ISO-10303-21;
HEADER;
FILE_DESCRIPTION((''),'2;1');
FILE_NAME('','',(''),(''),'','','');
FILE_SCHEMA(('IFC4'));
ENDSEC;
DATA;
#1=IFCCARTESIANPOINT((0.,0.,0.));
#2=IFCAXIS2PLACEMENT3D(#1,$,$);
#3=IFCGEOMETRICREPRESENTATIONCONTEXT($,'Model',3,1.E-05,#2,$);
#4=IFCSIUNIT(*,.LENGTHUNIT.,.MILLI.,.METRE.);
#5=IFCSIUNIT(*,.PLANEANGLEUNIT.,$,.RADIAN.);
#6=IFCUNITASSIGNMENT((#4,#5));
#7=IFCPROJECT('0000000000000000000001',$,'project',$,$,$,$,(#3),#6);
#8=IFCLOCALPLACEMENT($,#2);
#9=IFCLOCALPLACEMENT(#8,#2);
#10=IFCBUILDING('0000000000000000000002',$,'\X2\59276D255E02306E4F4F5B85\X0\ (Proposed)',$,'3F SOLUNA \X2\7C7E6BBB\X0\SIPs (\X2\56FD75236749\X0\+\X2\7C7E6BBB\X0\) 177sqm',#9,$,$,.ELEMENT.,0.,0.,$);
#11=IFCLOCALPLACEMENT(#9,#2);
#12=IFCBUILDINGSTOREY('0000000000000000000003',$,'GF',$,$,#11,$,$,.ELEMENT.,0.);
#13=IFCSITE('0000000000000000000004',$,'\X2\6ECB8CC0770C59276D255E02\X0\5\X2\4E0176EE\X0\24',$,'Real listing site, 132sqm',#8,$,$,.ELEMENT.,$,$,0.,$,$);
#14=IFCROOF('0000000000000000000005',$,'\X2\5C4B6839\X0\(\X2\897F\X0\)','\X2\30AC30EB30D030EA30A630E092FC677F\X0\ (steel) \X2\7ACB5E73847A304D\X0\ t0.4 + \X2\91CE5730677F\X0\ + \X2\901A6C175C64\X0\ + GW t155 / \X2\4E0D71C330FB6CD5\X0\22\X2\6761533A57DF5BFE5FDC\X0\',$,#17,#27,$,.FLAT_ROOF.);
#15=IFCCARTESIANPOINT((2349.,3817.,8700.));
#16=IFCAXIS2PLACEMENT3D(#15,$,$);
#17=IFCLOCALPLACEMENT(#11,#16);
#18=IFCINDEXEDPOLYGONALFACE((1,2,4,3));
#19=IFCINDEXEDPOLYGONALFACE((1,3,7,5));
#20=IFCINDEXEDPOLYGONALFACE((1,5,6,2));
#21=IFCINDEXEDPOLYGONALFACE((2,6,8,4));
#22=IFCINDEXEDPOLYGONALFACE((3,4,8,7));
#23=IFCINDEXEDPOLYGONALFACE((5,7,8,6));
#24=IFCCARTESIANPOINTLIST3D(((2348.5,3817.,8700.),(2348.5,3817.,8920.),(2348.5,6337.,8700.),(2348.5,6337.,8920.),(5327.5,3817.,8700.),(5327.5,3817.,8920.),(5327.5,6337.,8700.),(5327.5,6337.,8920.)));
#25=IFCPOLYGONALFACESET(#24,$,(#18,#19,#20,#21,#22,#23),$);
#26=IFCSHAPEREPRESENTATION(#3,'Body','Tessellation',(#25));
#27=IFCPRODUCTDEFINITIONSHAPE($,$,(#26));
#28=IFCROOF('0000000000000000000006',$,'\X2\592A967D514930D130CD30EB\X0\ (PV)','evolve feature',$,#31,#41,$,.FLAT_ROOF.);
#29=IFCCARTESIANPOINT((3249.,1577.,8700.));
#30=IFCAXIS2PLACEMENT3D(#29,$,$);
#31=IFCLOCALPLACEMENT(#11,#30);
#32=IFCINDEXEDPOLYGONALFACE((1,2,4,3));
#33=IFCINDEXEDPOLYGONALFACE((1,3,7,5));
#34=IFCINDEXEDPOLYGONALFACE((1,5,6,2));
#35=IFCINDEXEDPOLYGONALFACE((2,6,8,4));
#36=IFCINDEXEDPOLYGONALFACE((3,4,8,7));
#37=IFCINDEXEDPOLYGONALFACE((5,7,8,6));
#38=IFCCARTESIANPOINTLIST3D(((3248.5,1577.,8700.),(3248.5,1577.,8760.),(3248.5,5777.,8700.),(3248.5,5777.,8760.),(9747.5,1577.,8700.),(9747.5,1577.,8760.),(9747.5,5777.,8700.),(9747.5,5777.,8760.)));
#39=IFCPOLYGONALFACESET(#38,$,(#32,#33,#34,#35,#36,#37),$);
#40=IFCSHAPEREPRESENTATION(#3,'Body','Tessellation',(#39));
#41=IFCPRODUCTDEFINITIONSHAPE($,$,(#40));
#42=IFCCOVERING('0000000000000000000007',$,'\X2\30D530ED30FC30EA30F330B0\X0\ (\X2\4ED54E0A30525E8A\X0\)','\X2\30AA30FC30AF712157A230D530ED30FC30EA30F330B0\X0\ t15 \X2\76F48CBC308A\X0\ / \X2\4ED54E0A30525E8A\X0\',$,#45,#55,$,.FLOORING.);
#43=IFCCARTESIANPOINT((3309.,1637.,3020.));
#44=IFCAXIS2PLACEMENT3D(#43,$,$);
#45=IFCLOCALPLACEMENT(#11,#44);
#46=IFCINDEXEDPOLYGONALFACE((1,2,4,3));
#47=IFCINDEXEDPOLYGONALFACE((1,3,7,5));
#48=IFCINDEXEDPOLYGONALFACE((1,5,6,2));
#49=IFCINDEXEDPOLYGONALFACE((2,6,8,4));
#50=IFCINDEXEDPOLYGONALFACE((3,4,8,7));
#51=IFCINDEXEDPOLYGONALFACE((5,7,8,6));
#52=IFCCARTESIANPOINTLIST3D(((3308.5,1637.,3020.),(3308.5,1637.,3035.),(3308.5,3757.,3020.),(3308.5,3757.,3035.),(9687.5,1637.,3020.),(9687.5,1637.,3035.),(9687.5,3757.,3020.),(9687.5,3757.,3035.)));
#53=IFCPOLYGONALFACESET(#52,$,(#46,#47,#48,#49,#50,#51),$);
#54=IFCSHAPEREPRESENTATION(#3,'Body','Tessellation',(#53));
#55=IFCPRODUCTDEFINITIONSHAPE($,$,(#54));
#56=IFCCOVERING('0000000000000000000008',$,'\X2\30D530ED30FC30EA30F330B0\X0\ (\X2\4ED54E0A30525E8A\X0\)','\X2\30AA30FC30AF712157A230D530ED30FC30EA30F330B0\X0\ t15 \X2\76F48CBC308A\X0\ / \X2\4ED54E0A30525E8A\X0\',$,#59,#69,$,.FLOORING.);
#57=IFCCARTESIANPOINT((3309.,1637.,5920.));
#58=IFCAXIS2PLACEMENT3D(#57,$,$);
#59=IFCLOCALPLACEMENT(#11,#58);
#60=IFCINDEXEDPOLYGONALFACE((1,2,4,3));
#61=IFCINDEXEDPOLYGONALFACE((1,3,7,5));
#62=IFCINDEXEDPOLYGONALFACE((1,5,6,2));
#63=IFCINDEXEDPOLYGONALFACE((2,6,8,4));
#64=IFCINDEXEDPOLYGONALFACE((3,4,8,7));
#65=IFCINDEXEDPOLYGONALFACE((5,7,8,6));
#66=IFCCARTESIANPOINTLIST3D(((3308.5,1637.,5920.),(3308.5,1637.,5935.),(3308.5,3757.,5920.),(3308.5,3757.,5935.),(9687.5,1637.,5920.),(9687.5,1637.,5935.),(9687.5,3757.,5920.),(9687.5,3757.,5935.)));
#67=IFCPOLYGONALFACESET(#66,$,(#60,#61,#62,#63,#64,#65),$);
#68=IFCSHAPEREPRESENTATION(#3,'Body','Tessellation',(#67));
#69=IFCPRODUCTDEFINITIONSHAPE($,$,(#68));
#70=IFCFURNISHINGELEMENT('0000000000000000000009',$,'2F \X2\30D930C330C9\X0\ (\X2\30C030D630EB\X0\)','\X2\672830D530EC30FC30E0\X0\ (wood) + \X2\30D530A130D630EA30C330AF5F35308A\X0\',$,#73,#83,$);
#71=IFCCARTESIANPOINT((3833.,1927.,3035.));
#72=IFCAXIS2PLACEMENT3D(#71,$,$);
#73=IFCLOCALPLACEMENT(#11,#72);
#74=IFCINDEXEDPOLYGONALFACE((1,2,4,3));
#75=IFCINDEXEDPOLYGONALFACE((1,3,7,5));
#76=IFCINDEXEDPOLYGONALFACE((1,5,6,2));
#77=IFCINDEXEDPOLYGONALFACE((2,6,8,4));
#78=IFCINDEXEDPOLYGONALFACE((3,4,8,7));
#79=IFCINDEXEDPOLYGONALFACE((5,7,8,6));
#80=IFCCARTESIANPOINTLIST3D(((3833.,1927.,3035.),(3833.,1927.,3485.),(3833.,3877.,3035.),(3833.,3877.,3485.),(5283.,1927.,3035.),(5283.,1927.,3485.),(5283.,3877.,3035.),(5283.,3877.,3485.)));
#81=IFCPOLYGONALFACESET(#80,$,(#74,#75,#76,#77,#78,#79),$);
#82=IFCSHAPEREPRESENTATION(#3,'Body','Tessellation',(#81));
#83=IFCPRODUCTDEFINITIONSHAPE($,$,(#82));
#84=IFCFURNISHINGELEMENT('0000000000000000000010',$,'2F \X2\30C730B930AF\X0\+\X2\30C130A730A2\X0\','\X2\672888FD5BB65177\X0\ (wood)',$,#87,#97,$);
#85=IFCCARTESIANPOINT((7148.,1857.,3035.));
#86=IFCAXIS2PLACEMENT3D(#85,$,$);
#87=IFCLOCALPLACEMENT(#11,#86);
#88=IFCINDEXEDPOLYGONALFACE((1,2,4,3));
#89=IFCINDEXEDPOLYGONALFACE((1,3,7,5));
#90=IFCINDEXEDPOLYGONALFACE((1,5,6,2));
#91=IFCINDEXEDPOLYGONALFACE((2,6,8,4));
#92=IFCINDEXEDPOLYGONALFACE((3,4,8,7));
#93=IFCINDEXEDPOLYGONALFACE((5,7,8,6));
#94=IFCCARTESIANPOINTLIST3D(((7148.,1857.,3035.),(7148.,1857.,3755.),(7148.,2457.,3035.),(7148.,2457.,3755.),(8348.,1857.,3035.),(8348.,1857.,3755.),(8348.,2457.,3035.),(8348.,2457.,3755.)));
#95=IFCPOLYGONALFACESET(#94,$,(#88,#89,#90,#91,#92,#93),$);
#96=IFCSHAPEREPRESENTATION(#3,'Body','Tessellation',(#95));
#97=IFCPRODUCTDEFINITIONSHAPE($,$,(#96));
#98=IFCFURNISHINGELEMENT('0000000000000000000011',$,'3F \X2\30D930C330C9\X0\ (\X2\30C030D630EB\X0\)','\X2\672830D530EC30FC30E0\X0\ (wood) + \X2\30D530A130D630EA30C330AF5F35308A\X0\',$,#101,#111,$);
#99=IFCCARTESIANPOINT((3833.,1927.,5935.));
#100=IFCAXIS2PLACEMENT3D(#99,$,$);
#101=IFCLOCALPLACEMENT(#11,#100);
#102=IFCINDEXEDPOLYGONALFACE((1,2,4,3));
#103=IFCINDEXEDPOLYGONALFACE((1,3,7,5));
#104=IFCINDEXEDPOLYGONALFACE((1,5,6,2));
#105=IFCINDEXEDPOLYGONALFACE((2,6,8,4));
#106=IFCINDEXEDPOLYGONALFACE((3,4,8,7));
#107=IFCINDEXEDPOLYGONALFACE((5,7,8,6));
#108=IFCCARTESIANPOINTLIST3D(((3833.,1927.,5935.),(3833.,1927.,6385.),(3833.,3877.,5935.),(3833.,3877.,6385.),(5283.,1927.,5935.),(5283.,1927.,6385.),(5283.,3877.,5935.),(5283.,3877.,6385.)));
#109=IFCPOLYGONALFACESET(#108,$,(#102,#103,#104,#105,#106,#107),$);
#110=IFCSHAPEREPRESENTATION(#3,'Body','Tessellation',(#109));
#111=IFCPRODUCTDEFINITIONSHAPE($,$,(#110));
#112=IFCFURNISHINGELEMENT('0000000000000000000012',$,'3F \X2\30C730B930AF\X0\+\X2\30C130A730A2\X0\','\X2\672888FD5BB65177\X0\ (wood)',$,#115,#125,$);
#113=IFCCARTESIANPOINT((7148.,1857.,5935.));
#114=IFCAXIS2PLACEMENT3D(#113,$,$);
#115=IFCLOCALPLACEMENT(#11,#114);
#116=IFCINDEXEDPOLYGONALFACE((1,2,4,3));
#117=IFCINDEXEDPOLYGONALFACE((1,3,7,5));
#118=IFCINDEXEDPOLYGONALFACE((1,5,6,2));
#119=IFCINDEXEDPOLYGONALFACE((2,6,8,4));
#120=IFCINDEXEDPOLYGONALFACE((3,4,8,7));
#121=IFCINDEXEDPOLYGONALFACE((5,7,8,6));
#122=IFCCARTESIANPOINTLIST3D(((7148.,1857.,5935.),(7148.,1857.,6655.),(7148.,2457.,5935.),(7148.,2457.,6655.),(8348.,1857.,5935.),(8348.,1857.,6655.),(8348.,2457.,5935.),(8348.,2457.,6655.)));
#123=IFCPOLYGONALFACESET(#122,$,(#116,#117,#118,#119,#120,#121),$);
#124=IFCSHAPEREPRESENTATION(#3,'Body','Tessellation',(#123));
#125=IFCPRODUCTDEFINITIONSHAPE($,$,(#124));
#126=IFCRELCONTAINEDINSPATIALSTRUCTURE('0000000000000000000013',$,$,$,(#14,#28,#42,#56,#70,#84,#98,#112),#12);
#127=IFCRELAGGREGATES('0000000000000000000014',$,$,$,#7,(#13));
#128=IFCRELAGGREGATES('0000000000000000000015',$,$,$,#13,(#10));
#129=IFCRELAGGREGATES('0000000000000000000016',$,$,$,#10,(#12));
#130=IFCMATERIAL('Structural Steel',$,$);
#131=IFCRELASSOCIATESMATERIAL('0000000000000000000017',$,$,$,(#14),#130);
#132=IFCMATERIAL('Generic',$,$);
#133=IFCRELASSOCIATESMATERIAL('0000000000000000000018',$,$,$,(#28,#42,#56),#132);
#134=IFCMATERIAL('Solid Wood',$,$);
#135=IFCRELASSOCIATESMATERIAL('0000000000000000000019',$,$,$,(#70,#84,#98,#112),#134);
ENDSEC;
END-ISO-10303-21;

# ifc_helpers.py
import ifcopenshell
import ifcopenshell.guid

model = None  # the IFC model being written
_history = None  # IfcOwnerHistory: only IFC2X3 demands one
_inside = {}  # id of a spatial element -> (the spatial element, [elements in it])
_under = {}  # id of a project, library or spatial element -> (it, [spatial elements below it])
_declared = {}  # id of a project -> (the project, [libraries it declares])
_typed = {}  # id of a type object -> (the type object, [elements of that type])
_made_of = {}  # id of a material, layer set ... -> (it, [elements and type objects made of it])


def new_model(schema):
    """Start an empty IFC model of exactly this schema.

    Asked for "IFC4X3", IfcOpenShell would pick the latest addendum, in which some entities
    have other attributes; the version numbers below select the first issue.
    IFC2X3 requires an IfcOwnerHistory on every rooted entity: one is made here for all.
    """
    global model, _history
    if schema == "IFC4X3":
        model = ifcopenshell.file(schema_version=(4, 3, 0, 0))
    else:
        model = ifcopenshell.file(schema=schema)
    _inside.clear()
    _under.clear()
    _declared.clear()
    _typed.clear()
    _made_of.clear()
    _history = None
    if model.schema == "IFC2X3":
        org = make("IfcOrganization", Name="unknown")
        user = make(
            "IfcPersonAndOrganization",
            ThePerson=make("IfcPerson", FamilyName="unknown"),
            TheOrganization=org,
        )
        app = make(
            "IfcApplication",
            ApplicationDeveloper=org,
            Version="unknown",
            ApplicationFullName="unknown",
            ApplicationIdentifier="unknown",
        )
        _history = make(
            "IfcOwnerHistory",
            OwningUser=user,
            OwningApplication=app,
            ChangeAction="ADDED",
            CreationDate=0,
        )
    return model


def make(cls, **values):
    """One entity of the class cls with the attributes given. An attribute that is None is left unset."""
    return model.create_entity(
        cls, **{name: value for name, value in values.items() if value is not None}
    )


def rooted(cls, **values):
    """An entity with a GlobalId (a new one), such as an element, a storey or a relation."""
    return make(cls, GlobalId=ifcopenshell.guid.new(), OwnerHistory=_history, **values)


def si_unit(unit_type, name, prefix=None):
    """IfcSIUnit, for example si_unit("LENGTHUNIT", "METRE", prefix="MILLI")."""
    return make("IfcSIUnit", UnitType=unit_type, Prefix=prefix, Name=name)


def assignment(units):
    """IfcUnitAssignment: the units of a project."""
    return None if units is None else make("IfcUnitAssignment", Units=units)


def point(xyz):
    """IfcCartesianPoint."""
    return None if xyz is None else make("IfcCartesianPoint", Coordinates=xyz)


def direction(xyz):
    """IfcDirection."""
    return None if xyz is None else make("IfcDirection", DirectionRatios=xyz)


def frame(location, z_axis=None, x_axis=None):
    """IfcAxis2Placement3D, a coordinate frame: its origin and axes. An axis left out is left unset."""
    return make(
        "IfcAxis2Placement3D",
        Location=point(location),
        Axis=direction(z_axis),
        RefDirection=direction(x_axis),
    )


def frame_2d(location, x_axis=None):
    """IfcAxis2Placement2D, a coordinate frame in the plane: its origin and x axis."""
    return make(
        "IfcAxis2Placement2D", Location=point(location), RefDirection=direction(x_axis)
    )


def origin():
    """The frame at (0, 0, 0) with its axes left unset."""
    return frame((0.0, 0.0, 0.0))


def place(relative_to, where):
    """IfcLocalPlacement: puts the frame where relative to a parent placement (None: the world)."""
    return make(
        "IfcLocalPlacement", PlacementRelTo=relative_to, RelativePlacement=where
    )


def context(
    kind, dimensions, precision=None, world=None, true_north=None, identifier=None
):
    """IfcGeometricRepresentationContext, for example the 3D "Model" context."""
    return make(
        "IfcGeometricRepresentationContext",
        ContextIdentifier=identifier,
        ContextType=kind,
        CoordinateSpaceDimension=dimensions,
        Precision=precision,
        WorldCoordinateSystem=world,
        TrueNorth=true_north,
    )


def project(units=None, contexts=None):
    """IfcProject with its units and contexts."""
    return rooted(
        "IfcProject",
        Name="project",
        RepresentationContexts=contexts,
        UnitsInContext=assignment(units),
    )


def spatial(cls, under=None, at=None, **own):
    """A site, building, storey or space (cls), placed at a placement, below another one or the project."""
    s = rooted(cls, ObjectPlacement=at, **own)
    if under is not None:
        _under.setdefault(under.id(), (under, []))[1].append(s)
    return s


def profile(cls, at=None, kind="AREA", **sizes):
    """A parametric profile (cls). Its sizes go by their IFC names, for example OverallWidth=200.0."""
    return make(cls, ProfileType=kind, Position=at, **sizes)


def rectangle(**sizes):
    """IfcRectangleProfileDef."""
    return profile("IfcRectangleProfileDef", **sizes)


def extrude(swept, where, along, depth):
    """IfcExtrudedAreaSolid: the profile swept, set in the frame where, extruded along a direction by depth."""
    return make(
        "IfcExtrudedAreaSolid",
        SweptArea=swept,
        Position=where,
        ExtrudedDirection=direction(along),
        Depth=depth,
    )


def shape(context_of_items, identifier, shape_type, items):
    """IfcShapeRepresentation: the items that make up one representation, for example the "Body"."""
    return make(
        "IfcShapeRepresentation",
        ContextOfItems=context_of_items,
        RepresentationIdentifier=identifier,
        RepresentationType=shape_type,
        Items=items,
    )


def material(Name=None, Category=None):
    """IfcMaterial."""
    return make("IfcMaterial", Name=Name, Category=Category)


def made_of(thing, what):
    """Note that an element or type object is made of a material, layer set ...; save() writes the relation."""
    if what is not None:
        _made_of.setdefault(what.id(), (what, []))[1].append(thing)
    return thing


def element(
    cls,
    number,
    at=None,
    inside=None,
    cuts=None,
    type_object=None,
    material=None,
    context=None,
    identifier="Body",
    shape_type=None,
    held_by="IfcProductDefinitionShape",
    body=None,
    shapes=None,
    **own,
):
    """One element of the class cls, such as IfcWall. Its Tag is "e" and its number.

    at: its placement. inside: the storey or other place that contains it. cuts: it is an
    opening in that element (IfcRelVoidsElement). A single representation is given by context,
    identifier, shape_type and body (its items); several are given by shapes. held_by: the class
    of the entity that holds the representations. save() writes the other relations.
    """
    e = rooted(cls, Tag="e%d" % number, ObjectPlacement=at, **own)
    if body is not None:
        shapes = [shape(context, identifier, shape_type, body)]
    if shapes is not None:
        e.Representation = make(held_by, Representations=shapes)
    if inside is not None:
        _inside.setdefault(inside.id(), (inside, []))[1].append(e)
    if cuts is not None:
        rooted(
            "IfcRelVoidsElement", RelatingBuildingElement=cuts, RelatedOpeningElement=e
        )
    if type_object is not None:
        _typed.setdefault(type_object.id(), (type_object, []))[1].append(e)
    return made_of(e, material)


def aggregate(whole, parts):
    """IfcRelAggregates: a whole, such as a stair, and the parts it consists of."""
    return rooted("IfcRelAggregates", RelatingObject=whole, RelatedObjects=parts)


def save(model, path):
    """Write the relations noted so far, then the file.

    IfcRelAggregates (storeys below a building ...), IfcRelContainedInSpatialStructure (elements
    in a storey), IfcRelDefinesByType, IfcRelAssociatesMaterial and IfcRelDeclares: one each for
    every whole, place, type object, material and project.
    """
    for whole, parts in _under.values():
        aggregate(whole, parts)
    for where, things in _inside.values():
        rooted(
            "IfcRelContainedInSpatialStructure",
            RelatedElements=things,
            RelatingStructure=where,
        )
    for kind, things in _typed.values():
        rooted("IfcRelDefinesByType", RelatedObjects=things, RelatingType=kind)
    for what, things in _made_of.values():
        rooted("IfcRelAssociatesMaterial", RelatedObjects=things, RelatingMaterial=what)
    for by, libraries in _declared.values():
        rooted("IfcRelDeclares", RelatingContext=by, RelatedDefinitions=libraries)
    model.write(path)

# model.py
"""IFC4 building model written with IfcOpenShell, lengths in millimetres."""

from ifc_helpers import new_model, si_unit, frame, frame_2d, origin, place, context, project, spatial, rectangle, extrude, material, element, save


model = new_model("IFC4")

# Units and contexts
model_context = context("Model", 3, precision=1e-05, world=origin())
ifc_project = project(units=[si_unit("LENGTHUNIT", "METRE", prefix="MILLI"), si_unit("PLANEANGLEUNIT", "RADIAN")], contexts=[model_context])

# Site, building, storey
site_placement = place(None, origin())
site = spatial("IfcSite", under=ifc_project, at=site_placement, Name="滋賀県大津市5丁目24", ObjectType="Real listing site, 132sqm", CompositionType="ELEMENT", RefElevation=0.0)
building_placement = place(site_placement, origin())
building = spatial("IfcBuilding", under=site, at=building_placement, Name="大津市の住宅 (Proposed)", ObjectType="3F SOLUNA 籾殻SIPs (国産杉+籾殻) 177sqm", CompositionType="ELEMENT", ElevationOfRefHeight=0.0, ElevationOfTerrain=0.0)
storey_placement = place(building_placement, origin())
storey = spatial("IfcBuildingStorey", under=building, at=storey_placement, Name="GF", CompositionType="ELEMENT", Elevation=0.0)

# Shared definitions
ifc_material_1 = material(Name="Solid Wood")

# Roofs
ifc_material_2 = material(Name="Structural Steel")
roof_1_placement = place(storey_placement, frame((2349.0, 3817.0, 8700.0)))
element("IfcRoof", 1, at=roof_1_placement, inside=storey, material=ifc_material_2, Name="屋根(西)", Description="ガルバリウム鋼板 (steel) 立平葺き t0.4 + 野地板 + 通気層 + GW t155 / 不燃・法22条区域対応", PredefinedType="FLAT_ROOF", context=model_context, shape_type="SweptSolid", body=[
    extrude(rectangle(XDim=2979.0, YDim=2520.0, at=frame_2d((1489.0, 1260.0))), frame((2349.0, 3817.0, 8700.0)), (0.0, 0.0, 1.0), 220.0),
])
ifc_material_3 = material(Name="Generic")
roof_2_placement = place(storey_placement, frame((3249.0, 1577.0, 8700.0)))
element("IfcRoof", 2, at=roof_2_placement, inside=storey, material=ifc_material_3, Name="太陽光パネル (PV)", Description="evolve feature", PredefinedType="FLAT_ROOF", context=model_context, shape_type="SweptSolid", body=[
    extrude(rectangle(XDim=6499.0, YDim=4200.0, at=frame_2d((3249.0, 2100.0))), frame((3249.0, 1577.0, 8700.0)), (0.0, 0.0, 1.0), 60.0),
])

# Coverings
covering_1_placement = place(storey_placement, frame((3309.0, 1637.0, 3020.0)))
element("IfcCovering", 3, at=covering_1_placement, inside=storey, material=ifc_material_3, Name="フローリング (仕上げ床)", Description="オーク無垢フローリング t15 直貼り / 仕上げ床", PredefinedType="FLOORING", context=model_context, shape_type="SweptSolid", body=[
    extrude(rectangle(XDim=6379.0, YDim=2120.0, at=frame_2d((3189.0, 1060.0))), frame((3309.0, 1637.0, 3020.0)), (0.0, 0.0, 1.0), 15.0),
])
covering_2_placement = place(storey_placement, frame((3309.0, 1637.0, 5920.0)))
element("IfcCovering", 4, at=covering_2_placement, inside=storey, material=ifc_material_3, Name="フローリング (仕上げ床)", Description="オーク無垢フローリング t15 直貼り / 仕上げ床", PredefinedType="FLOORING", context=model_context, shape_type="SweptSolid", body=[
    extrude(rectangle(XDim=6379.0, YDim=2120.0, at=frame_2d((3189.0, 1060.0))), frame((3309.0, 1637.0, 5920.0)), (0.0, 0.0, 1.0), 15.0),
])

# Furnishing elements
furnishing_1_placement = place(storey_placement, frame((3833.0, 1927.0, 3035.0)))
element("IfcFurnishingElement", 5, at=furnishing_1_placement, inside=storey, material=ifc_material_1, Name="2F ベッド (ダブル)", Description="木フレーム (wood) + ファブリック張り", context=model_context, shape_type="SweptSolid", body=[
    extrude(rectangle(XDim=1450.0, YDim=1950.0, at=frame_2d((725.0, 975.0))), frame((3833.0, 1927.0, 3035.0)), (0.0, 0.0, 1.0), 450.0),
])
furnishing_2_placement = place(storey_placement, frame((7148.0, 1857.0, 3035.0)))
element("IfcFurnishingElement", 6, at=furnishing_2_placement, inside=storey, material=ifc_material_1, Name="2F デスク+チェア", Description="木製家具 (wood)", context=model_context, shape_type="SweptSolid", body=[
    extrude(rectangle(XDim=1200.0, YDim=600.0, at=frame_2d((600.0, 300.0))), frame((7148.0, 1857.0, 3035.0)), (0.0, 0.0, 1.0), 720.0),
])
furnishing_3_placement = place(storey_placement, frame((3833.0, 1927.0, 5935.0)))
element("IfcFurnishingElement", 7, at=furnishing_3_placement, inside=storey, material=ifc_material_1, Name="3F ベッド (ダブル)", Description="木フレーム (wood) + ファブリック張り", context=model_context, shape_type="SweptSolid", body=[
    extrude(rectangle(XDim=1450.0, YDim=1950.0, at=frame_2d((725.0, 975.0))), frame((3833.0, 1927.0, 5935.0)), (0.0, 0.0, 1.0), 450.0),
])
furnishing_4_placement = place(storey_placement, frame((7148.0, 1857.0, 5935.0)))
element("IfcFurnishingElement", 8, at=furnishing_4_placement, inside=storey, material=ifc_material_1, Name="3F デスク+チェア", Description="木製家具 (wood)", context=model_context, shape_type="SweptSolid", body=[
    extrude(rectangle(XDim=1200.0, YDim=600.0, at=frame_2d((600.0, 300.0))), frame((7148.0, 1857.0, 5935.0)), (0.0, 0.0, 1.0), 720.0),
])

save(model, "model.ifc")
